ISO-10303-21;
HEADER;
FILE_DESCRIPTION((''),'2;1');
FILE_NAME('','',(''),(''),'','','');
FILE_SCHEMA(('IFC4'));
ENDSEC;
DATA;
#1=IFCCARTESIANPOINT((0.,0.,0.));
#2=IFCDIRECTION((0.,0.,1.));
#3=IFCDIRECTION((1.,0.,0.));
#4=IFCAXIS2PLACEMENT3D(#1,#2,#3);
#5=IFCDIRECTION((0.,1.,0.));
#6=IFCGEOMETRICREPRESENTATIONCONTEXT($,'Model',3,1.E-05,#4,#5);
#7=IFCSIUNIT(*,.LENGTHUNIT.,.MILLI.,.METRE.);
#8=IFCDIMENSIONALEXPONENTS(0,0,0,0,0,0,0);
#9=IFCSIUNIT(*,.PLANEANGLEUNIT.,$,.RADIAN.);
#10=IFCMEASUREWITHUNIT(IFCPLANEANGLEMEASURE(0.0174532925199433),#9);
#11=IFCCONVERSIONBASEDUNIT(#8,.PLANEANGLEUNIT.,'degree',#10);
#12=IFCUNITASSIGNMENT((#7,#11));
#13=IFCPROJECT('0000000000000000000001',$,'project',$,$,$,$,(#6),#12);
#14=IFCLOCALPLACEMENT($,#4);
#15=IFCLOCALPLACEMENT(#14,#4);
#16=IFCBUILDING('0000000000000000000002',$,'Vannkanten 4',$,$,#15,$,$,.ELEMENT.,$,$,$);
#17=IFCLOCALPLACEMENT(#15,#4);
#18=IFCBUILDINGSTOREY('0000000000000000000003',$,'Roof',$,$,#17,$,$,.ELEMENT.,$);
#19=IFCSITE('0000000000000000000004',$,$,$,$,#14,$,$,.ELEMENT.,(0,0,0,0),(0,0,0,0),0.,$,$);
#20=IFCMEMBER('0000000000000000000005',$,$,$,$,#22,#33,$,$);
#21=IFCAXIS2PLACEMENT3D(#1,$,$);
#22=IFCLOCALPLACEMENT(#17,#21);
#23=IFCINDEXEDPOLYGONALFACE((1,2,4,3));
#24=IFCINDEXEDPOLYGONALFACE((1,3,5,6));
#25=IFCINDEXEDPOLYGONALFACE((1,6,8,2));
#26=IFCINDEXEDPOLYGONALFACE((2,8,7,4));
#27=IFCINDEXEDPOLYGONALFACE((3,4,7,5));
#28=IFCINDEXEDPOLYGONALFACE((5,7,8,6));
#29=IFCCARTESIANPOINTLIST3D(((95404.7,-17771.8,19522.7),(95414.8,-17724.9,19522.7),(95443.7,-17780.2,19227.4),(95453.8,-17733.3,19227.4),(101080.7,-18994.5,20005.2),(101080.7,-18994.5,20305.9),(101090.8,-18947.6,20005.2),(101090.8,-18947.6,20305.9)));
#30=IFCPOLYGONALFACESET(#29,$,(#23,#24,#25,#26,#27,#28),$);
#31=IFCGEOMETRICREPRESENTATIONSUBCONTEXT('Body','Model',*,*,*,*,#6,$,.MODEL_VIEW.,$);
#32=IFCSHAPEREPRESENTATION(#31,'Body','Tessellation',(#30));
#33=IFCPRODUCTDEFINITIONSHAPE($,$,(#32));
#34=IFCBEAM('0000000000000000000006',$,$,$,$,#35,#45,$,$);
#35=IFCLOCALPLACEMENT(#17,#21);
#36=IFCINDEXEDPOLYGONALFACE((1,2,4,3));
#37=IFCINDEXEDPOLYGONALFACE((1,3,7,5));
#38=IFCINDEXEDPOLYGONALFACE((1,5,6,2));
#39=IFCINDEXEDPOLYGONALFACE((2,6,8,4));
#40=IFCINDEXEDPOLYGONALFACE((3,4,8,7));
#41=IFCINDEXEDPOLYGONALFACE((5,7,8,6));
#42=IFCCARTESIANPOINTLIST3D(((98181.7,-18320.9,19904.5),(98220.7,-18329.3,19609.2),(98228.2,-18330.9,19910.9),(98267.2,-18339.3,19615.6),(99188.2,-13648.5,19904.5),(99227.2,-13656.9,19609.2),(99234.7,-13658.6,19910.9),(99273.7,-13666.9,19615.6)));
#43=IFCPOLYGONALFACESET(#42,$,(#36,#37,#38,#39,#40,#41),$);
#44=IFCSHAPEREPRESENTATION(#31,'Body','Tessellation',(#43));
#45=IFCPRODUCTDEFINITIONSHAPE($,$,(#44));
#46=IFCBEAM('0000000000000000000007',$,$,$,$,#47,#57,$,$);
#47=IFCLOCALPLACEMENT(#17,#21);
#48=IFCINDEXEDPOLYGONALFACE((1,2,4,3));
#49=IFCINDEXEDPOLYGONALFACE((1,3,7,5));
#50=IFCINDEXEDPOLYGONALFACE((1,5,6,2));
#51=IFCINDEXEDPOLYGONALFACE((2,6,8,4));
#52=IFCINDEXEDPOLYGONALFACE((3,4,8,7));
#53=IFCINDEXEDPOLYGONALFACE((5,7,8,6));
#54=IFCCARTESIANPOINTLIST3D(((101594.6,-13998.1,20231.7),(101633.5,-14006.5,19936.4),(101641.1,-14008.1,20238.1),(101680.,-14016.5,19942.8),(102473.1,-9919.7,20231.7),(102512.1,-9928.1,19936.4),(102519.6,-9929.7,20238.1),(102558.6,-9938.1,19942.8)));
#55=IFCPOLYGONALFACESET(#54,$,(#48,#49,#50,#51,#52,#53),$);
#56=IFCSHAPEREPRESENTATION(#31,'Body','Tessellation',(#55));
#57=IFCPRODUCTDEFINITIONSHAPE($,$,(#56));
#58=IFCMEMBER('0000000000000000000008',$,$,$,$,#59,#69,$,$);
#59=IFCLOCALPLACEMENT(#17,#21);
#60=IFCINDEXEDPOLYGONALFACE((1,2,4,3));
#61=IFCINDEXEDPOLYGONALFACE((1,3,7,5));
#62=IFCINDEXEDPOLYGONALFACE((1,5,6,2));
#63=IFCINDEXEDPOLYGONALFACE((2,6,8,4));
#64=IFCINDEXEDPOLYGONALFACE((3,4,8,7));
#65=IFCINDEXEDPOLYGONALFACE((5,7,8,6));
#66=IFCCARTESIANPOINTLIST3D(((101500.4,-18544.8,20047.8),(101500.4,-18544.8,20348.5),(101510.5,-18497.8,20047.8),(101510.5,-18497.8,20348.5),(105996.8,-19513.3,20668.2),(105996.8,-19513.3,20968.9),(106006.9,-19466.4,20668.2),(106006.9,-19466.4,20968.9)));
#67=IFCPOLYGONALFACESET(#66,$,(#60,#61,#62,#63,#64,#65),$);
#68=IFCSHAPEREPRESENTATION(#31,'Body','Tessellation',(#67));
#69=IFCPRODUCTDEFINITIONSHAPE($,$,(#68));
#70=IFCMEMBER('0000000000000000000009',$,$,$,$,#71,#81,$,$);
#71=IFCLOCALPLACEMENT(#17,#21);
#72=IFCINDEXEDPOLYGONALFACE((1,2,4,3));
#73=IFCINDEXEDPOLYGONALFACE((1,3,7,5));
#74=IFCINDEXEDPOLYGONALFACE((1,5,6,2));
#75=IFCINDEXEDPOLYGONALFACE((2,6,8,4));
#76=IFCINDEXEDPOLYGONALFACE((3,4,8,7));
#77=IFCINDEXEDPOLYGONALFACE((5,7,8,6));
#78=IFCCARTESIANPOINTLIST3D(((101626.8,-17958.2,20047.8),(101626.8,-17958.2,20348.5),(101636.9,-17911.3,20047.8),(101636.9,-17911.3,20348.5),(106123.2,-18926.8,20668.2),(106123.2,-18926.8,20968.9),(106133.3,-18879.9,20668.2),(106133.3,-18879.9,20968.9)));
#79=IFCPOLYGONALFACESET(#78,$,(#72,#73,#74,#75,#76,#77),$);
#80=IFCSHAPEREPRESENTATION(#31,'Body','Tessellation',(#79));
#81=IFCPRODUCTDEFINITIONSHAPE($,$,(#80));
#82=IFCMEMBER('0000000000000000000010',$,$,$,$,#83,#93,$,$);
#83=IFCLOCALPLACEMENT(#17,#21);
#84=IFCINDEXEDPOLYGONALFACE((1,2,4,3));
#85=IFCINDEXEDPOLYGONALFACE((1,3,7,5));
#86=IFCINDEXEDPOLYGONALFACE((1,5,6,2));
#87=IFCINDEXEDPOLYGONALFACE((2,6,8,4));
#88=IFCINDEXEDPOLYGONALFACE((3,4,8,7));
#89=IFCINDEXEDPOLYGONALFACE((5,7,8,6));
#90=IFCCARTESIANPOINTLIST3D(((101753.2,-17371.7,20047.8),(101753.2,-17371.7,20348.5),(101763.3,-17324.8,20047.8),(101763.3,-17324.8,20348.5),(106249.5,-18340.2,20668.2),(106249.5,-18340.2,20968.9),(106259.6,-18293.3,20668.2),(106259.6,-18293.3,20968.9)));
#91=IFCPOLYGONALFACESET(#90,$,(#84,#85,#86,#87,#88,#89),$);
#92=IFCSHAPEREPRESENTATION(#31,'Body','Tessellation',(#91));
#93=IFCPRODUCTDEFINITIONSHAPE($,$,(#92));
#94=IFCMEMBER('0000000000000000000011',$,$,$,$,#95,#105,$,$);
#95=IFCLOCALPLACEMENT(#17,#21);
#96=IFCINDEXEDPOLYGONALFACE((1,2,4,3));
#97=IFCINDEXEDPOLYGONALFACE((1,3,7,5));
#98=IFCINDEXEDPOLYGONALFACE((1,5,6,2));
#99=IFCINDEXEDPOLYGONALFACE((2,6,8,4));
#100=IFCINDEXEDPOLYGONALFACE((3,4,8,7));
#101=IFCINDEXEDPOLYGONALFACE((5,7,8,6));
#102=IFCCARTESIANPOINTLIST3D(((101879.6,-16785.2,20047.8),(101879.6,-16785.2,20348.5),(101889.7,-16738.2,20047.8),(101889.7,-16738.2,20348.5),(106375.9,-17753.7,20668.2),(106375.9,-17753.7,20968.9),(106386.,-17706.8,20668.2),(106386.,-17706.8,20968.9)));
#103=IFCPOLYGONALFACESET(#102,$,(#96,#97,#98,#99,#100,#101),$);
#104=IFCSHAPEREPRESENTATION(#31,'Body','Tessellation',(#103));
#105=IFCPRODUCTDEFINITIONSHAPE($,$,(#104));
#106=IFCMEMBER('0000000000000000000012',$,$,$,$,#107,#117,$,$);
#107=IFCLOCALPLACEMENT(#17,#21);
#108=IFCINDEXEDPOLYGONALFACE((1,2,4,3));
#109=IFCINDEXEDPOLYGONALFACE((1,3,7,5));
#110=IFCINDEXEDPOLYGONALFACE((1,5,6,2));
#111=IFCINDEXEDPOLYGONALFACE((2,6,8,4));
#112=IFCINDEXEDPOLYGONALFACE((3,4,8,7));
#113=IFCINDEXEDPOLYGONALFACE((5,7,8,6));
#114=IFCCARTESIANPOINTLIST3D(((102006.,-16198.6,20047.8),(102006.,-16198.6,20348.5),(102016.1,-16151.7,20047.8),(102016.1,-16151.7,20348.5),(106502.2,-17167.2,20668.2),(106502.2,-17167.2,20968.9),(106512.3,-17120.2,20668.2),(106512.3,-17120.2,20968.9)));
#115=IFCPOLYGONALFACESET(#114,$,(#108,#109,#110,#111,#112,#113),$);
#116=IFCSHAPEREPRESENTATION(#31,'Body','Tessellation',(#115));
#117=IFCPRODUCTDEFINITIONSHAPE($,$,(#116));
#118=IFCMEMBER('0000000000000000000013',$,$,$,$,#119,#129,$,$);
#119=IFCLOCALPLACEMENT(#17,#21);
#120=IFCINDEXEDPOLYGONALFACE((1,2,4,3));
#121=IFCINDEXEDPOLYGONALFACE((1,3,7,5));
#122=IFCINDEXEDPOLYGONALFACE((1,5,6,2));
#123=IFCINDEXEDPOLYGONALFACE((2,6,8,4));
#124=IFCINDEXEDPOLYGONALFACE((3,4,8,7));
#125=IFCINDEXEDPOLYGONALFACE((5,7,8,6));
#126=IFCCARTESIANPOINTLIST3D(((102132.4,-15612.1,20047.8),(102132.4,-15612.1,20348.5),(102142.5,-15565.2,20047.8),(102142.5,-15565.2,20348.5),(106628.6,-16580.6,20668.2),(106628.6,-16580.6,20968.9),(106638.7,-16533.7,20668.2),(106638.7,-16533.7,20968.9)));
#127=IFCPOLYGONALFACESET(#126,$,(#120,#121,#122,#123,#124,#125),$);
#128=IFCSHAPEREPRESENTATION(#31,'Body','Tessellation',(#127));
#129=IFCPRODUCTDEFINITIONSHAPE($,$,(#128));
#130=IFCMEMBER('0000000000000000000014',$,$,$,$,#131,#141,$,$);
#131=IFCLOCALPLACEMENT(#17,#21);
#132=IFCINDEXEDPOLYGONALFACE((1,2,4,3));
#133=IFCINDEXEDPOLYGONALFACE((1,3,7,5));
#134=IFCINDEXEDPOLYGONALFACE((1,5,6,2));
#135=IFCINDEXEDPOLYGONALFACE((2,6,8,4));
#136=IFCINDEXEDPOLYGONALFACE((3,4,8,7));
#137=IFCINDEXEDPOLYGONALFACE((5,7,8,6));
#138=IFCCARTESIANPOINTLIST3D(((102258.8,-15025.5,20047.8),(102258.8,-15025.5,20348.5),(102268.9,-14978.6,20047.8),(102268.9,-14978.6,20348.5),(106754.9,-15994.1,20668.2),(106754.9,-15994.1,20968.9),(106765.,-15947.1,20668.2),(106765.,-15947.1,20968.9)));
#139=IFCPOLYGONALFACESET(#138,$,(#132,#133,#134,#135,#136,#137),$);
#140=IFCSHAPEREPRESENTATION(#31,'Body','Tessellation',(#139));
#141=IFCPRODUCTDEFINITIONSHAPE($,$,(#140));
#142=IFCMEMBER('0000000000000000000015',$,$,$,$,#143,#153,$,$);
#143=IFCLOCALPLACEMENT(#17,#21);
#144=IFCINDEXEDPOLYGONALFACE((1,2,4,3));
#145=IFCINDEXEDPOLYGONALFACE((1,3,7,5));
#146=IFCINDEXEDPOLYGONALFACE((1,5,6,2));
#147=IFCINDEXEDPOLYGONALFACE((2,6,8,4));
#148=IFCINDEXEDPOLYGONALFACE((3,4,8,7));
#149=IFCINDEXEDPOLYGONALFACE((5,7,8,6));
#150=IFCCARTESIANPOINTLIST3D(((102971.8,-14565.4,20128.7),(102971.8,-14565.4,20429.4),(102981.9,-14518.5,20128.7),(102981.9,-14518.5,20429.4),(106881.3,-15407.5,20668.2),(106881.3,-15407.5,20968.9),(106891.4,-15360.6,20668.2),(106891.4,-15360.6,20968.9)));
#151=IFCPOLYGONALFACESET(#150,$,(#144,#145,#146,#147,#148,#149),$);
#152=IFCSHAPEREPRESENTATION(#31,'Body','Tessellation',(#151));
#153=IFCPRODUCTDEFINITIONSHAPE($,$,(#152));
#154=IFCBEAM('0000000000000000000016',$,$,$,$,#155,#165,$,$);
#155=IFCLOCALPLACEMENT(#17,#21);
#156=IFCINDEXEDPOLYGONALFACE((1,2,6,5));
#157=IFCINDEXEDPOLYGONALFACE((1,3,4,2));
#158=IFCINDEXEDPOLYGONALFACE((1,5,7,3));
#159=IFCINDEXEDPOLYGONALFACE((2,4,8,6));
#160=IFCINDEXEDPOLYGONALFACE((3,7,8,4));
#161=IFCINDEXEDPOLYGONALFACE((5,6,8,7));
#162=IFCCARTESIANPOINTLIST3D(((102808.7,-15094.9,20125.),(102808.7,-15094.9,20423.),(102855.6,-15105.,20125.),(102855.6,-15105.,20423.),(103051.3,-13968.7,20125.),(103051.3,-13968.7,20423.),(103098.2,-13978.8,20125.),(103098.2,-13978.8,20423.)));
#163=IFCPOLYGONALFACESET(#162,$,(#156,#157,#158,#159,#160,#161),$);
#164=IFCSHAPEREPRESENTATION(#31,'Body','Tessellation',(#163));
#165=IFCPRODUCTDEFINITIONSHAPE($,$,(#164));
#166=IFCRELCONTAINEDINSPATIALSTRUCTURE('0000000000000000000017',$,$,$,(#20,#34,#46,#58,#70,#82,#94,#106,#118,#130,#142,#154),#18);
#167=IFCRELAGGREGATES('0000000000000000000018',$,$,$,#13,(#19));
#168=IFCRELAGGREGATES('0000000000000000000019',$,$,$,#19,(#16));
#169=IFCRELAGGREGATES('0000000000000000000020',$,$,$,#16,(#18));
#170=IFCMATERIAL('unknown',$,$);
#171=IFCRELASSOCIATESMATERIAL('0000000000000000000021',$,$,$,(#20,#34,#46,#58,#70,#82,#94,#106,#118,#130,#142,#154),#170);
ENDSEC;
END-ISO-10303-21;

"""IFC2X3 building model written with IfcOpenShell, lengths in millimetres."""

from ifc_helpers import new_model, entity, si_unit, converted_unit, direction, frame, origin_with_axes, place, context, subcontext, project, spatial, polyline, segment, composite_curve, outline, extrude, clip, halfspace, material, element, save


model = new_model("IFC2X3")

# Units and contexts
model_context = context("Model", 3, precision=1e-05, world=origin_with_axes(), true_north=direction((0.0, 1.0, 0.0)))
body_context = subcontext(model_context, "Body", "Model", "MODEL_VIEW")
ifc_project = project(units=[si_unit("LENGTHUNIT", "METRE", prefix="MILLI"), converted_unit("PLANEANGLEUNIT", "degree", entity("IfcPlaneAngleMeasure", 0.0174532925199433), si_unit("PLANEANGLEUNIT", "RADIAN"), dimensions=[0, 0, 0, 0, 0, 0, 0])], contexts=[model_context])

# Site, building, storey
site_placement = place(None, origin_with_axes())
site = spatial("IfcSite", under=ifc_project, at=site_placement, CompositionType="ELEMENT", RefLatitude=(0, 0, 0, 0), RefLongitude=(0, 0, 0, 0), RefElevation=0.0)
building_placement = place(site_placement, origin_with_axes())
building = spatial("IfcBuilding", under=site, at=building_placement, Name="Vannkanten 4", CompositionType="ELEMENT")
storey_placement = place(building_placement, origin_with_axes())
storey = spatial("IfcBuildingStorey", under=building, at=storey_placement, Name="Roof", CompositionType="ELEMENT")

# Member
ifc_material = material(Name="unknown")
member_1_placement = place(storey_placement, frame((101085.7, -18971.0, 20155.5), z_axis=(-0.968803, 0.208692, -0.133675), x_axis=(-0.210582, -0.977576, 0.0)))
element("IfcMember", 1, at=member_1_placement, inside=storey, material=ifc_material, context=body_context, shape_type="Clipping", body=[
    clip(extrude(outline(composite_curve([segment(polyline([(-24.0, -149.0), (-24.0, 149.0), (24.0, 149.0), (24.0, -149.0), (-24.0, -149.0)]), True, "CONTINUOUS")], self_intersect=False)), frame((0.0, 0.0, -2949.5), z_axis=(0.0, 0.0, 1.0), x_axis=(1.0, 0.0, 0.0)), (0.0, 0.0, 1.0), 8788.1), halfspace(frame((-24.0, 149.0, -20.1), z_axis=(0.0, 0.133675, 0.991025), x_axis=(0.0, 0.991025, -0.133675)), True)),
])

# Beams
beam_1_placement = place(storey_placement, frame((98224.5, -18330.1, 19760.0), z_axis=(0.210582, 0.977576, 0.0), x_axis=(-0.968803, 0.208692, -0.133675)))
element("IfcBeam", 2, at=beam_1_placement, inside=storey, material=ifc_material, context=body_context, shape_type="SweptSolid", body=[
    extrude(outline(composite_curve([segment(polyline([(-24.0, -149.0), (-24.0, 149.0), (24.0, 149.0), (24.0, -149.0), (-24.0, -149.0)]), True, "CONTINUOUS")], self_intersect=False)), frame((0.0, 0.0, 0.0), z_axis=(0.0, 0.0, 1.0), x_axis=(1.0, 0.0, 0.0)), (0.0, 0.0, 1.0), 4779.6),
])
beam_2_placement = place(storey_placement, frame((101637.3, -14007.3, 20087.3), z_axis=(0.210582, 0.977576, 0.0), x_axis=(-0.968803, 0.208692, -0.133675)))
element("IfcBeam", 3, at=beam_2_placement, inside=storey, material=ifc_material, context=body_context, shape_type="SweptSolid", body=[
    extrude(outline(composite_curve([segment(polyline([(-24.0, -149.0), (-24.0, 149.0), (24.0, 149.0), (24.0, -149.0), (-24.0, -149.0)]), True, "CONTINUOUS")], self_intersect=False)), frame((0.0, 0.0, 0.0), z_axis=(0.0, 0.0, 1.0), x_axis=(1.0, 0.0, 0.0)), (0.0, 0.0, 1.0), 4172.0),
])

# Members
member_2_placement = place(storey_placement, frame((101505.5, -18521.3, 20198.1), z_axis=(0.968803, -0.208692, 0.133675), x_axis=(0.210582, 0.977576, 0.0)))
element("IfcMember", 4, at=member_2_placement, inside=storey, material=ifc_material, context=body_context, shape_type="Clipping", body=[
    clip(clip(extrude(outline(composite_curve([segment(polyline([(-24.0, -149.0), (-24.0, 149.0), (24.0, 149.0), (24.0, -149.0), (-24.0, -149.0)]), True, "CONTINUOUS")], self_intersect=False)), frame((0.0, 0.0, -2360.8), z_axis=(0.0, 0.0, 1.0), x_axis=(1.0, 0.0, 0.0)), (0.0, 0.0, 1.0), 9362.8), halfspace(frame((-24.0, 149.0, 20.1), z_axis=(-0.000083, -0.133675, 0.991025), x_axis=(0.0, 0.991025, 0.133675)), True)), halfspace(frame((24.0, 149.0, 4661.3), z_axis=(0.0, 0.133675, -0.991025), x_axis=(0.0, -0.991025, -0.133675)), True)),
])
member_3_placement = place(storey_placement, frame((101631.9, -17934.8, 20198.1), z_axis=(0.968803, -0.208692, 0.133675), x_axis=(0.210582, 0.977576, 0.0)))
element("IfcMember", 5, at=member_3_placement, inside=storey, material=ifc_material, context=body_context, shape_type="Clipping", body=[
    clip(clip(extrude(outline(composite_curve([segment(polyline([(-24.0, -149.0), (-24.0, 149.0), (24.0, 149.0), (24.0, -149.0), (-24.0, -149.0)]), True, "CONTINUOUS")], self_intersect=False)), frame((0.0, 0.0, -2360.8), z_axis=(0.0, 0.0, 1.0), x_axis=(1.0, 0.0, 0.0)), (0.0, 0.0, 1.0), 9362.7), halfspace(frame((-24.0, 149.0, 20.1), z_axis=(-0.000083, -0.133675, 0.991025), x_axis=(0.0, 0.991025, 0.133675)), True)), halfspace(frame((24.0, 149.0, 4661.2), z_axis=(0.0, 0.133675, -0.991025), x_axis=(0.0, -0.991025, -0.133675)), True)),
])
member_4_placement = place(storey_placement, frame((101758.3, -17348.2, 20198.1), z_axis=(0.968803, -0.208692, 0.133675), x_axis=(0.210582, 0.977576, 0.0)))
element("IfcMember", 6, at=member_4_placement, inside=storey, material=ifc_material, context=body_context, shape_type="Clipping", body=[
    clip(clip(extrude(outline(composite_curve([segment(polyline([(-24.0, -149.0), (-24.0, 149.0), (24.0, 149.0), (24.0, -149.0), (-24.0, -149.0)]), True, "CONTINUOUS")], self_intersect=False)), frame((0.0, 0.0, -2360.7), z_axis=(0.0, 0.0, 1.0), x_axis=(1.0, 0.0, 0.0)), (0.0, 0.0, 1.0), 9362.6), halfspace(frame((-24.0, 149.0, 20.1), z_axis=(-0.000083, -0.133675, 0.991025), x_axis=(0.0, 0.991025, 0.133675)), True)), halfspace(frame((24.0, 149.0, 4661.2), z_axis=(0.0, 0.133675, -0.991025), x_axis=(0.0, -0.991025, -0.133675)), True)),
])
member_5_placement = place(storey_placement, frame((101884.7, -16761.7, 20198.1), z_axis=(0.968803, -0.208692, 0.133675), x_axis=(0.210582, 0.977576, 0.0)))
element("IfcMember", 7, at=member_5_placement, inside=storey, material=ifc_material, context=body_context, shape_type="Clipping", body=[
    clip(clip(extrude(outline(composite_curve([segment(polyline([(-24.0, -149.0), (-24.0, 149.0), (24.0, 149.0), (24.0, -149.0), (-24.0, -149.0)]), True, "CONTINUOUS")], self_intersect=False)), frame((0.0, 0.0, -2360.7), z_axis=(0.0, 0.0, 1.0), x_axis=(1.0, 0.0, 0.0)), (0.0, 0.0, 1.0), 9362.5), halfspace(frame((-24.0, 149.0, 20.1), z_axis=(-0.000083, -0.133675, 0.991025), x_axis=(0.0, 0.991025, 0.133675)), True)), halfspace(frame((24.0, 149.0, 4661.1), z_axis=(0.0, 0.133675, -0.991025), x_axis=(0.0, -0.991025, -0.133675)), True)),
])
member_6_placement = place(storey_placement, frame((102011.1, -16175.2, 20198.1), z_axis=(0.968803, -0.208692, 0.133675), x_axis=(0.210582, 0.977576, 0.0)))
element("IfcMember", 8, at=member_6_placement, inside=storey, material=ifc_material, context=body_context, shape_type="Clipping", body=[
    clip(clip(extrude(outline(composite_curve([segment(polyline([(-24.0, -149.0), (-24.0, 149.0), (24.0, 149.0), (24.0, -149.0), (-24.0, -149.0)]), True, "CONTINUOUS")], self_intersect=False)), frame((0.0, 0.0, -2360.7), z_axis=(0.0, 0.0, 1.0), x_axis=(1.0, 0.0, 0.0)), (0.0, 0.0, 1.0), 9362.4), halfspace(frame((-24.0, 149.0, 20.1), z_axis=(-0.000083, -0.133675, 0.991025), x_axis=(0.0, 0.991025, 0.133675)), True)), halfspace(frame((24.0, 149.0, 4661.1), z_axis=(0.0, 0.133675, -0.991025), x_axis=(0.0, -0.991025, -0.133675)), True)),
])
member_7_placement = place(storey_placement, frame((102137.5, -15588.6, 20198.1), z_axis=(0.968803, -0.208692, 0.133675), x_axis=(0.210582, 0.977576, 0.0)))
element("IfcMember", 9, at=member_7_placement, inside=storey, material=ifc_material, context=body_context, shape_type="Clipping", body=[
    clip(clip(extrude(outline(composite_curve([segment(polyline([(-24.0, -149.0), (-24.0, 149.0), (24.0, 149.0), (24.0, -149.0), (-24.0, -149.0)]), True, "CONTINUOUS")], self_intersect=False)), frame((0.0, 0.0, -2360.7), z_axis=(0.0, 0.0, 1.0), x_axis=(1.0, 0.0, 0.0)), (0.0, 0.0, 1.0), 9362.3), halfspace(frame((-24.0, 149.0, 20.1), z_axis=(-0.000083, -0.133675, 0.991025), x_axis=(0.0, 0.991025, 0.133675)), True)), halfspace(frame((24.0, 149.0, 4661.0), z_axis=(0.0, 0.133675, -0.991025), x_axis=(0.0, -0.991025, -0.133675)), True)),
])
member_8_placement = place(storey_placement, frame((102263.9, -15002.1, 20198.1), z_axis=(0.968803, -0.208692, 0.133675), x_axis=(0.210582, 0.977576, 0.0)))
element("IfcMember", 10, at=member_8_placement, inside=storey, material=ifc_material, context=body_context, shape_type="Clipping", body=[
    clip(clip(extrude(outline(composite_curve([segment(polyline([(-24.0, -149.0), (-24.0, 149.0), (24.0, 149.0), (24.0, -149.0), (-24.0, -149.0)]), True, "CONTINUOUS")], self_intersect=False)), frame((0.0, 0.0, -2360.6), z_axis=(0.0, 0.0, 1.0), x_axis=(1.0, 0.0, 0.0)), (0.0, 0.0, 1.0), 9362.2), halfspace(frame((-24.0, 149.0, 20.1), z_axis=(-0.000083, -0.133675, 0.991025), x_axis=(0.0, 0.991025, 0.133675)), True)), halfspace(frame((24.0, 149.0, 4661.0), z_axis=(0.0, 0.133675, -0.991025), x_axis=(0.0, -0.991025, -0.133675)), True)),
])
member_9_placement = place(storey_placement, frame((102976.9, -14541.9, 20279.1), z_axis=(0.968803, -0.208692, 0.133675), x_axis=(0.210582, 0.977576, 0.0)))
element("IfcMember", 11, at=member_9_placement, inside=storey, material=ifc_material, context=body_context, shape_type="Clipping", body=[
    clip(clip(extrude(outline(composite_curve([segment(polyline([(-24.0, -149.0), (-24.0, 149.0), (24.0, 149.0), (24.0, -149.0), (-24.0, -149.0)]), True, "CONTINUOUS")], self_intersect=False)), frame((0.0, 0.0, -2057.9), z_axis=(0.0, 0.0, 1.0), x_axis=(1.0, 0.0, 0.0)), (0.0, 0.0, 1.0), 8151.0), halfspace(frame((-24.0, 149.0, 20.1), z_axis=(0.0, -0.133675, 0.991025), x_axis=(0.0, 0.991025, 0.133675)), True)), halfspace(frame((24.0, 149.0, 4055.4), z_axis=(0.0, 0.133675, -0.991025), x_axis=(0.0, -0.991025, -0.133675)), True)),
])

# Beam
beam_3_placement = place(storey_placement, frame((102832.1, -15099.9, 20274.0), z_axis=(0.210582, 0.977576, 0.0), x_axis=(-0.977576, 0.210582, 0.0)))
element("IfcBeam", 12, at=beam_3_placement, inside=storey, material=ifc_material, context=body_context, shape_type="SweptSolid", body=[
    extrude(outline(composite_curve([segment(polyline([(-24.0, -149.0), (-24.0, 149.0), (24.0, 149.0), (24.0, -149.0), (-24.0, -149.0)]), True, "CONTINUOUS")], self_intersect=False)), frame((0.0, 0.0, 0.0), z_axis=(0.0, 0.0, 1.0), x_axis=(1.0, 0.0, 0.0)), (0.0, 0.0, 1.0), 1152.0),
])

save(model, "model.ifc")
